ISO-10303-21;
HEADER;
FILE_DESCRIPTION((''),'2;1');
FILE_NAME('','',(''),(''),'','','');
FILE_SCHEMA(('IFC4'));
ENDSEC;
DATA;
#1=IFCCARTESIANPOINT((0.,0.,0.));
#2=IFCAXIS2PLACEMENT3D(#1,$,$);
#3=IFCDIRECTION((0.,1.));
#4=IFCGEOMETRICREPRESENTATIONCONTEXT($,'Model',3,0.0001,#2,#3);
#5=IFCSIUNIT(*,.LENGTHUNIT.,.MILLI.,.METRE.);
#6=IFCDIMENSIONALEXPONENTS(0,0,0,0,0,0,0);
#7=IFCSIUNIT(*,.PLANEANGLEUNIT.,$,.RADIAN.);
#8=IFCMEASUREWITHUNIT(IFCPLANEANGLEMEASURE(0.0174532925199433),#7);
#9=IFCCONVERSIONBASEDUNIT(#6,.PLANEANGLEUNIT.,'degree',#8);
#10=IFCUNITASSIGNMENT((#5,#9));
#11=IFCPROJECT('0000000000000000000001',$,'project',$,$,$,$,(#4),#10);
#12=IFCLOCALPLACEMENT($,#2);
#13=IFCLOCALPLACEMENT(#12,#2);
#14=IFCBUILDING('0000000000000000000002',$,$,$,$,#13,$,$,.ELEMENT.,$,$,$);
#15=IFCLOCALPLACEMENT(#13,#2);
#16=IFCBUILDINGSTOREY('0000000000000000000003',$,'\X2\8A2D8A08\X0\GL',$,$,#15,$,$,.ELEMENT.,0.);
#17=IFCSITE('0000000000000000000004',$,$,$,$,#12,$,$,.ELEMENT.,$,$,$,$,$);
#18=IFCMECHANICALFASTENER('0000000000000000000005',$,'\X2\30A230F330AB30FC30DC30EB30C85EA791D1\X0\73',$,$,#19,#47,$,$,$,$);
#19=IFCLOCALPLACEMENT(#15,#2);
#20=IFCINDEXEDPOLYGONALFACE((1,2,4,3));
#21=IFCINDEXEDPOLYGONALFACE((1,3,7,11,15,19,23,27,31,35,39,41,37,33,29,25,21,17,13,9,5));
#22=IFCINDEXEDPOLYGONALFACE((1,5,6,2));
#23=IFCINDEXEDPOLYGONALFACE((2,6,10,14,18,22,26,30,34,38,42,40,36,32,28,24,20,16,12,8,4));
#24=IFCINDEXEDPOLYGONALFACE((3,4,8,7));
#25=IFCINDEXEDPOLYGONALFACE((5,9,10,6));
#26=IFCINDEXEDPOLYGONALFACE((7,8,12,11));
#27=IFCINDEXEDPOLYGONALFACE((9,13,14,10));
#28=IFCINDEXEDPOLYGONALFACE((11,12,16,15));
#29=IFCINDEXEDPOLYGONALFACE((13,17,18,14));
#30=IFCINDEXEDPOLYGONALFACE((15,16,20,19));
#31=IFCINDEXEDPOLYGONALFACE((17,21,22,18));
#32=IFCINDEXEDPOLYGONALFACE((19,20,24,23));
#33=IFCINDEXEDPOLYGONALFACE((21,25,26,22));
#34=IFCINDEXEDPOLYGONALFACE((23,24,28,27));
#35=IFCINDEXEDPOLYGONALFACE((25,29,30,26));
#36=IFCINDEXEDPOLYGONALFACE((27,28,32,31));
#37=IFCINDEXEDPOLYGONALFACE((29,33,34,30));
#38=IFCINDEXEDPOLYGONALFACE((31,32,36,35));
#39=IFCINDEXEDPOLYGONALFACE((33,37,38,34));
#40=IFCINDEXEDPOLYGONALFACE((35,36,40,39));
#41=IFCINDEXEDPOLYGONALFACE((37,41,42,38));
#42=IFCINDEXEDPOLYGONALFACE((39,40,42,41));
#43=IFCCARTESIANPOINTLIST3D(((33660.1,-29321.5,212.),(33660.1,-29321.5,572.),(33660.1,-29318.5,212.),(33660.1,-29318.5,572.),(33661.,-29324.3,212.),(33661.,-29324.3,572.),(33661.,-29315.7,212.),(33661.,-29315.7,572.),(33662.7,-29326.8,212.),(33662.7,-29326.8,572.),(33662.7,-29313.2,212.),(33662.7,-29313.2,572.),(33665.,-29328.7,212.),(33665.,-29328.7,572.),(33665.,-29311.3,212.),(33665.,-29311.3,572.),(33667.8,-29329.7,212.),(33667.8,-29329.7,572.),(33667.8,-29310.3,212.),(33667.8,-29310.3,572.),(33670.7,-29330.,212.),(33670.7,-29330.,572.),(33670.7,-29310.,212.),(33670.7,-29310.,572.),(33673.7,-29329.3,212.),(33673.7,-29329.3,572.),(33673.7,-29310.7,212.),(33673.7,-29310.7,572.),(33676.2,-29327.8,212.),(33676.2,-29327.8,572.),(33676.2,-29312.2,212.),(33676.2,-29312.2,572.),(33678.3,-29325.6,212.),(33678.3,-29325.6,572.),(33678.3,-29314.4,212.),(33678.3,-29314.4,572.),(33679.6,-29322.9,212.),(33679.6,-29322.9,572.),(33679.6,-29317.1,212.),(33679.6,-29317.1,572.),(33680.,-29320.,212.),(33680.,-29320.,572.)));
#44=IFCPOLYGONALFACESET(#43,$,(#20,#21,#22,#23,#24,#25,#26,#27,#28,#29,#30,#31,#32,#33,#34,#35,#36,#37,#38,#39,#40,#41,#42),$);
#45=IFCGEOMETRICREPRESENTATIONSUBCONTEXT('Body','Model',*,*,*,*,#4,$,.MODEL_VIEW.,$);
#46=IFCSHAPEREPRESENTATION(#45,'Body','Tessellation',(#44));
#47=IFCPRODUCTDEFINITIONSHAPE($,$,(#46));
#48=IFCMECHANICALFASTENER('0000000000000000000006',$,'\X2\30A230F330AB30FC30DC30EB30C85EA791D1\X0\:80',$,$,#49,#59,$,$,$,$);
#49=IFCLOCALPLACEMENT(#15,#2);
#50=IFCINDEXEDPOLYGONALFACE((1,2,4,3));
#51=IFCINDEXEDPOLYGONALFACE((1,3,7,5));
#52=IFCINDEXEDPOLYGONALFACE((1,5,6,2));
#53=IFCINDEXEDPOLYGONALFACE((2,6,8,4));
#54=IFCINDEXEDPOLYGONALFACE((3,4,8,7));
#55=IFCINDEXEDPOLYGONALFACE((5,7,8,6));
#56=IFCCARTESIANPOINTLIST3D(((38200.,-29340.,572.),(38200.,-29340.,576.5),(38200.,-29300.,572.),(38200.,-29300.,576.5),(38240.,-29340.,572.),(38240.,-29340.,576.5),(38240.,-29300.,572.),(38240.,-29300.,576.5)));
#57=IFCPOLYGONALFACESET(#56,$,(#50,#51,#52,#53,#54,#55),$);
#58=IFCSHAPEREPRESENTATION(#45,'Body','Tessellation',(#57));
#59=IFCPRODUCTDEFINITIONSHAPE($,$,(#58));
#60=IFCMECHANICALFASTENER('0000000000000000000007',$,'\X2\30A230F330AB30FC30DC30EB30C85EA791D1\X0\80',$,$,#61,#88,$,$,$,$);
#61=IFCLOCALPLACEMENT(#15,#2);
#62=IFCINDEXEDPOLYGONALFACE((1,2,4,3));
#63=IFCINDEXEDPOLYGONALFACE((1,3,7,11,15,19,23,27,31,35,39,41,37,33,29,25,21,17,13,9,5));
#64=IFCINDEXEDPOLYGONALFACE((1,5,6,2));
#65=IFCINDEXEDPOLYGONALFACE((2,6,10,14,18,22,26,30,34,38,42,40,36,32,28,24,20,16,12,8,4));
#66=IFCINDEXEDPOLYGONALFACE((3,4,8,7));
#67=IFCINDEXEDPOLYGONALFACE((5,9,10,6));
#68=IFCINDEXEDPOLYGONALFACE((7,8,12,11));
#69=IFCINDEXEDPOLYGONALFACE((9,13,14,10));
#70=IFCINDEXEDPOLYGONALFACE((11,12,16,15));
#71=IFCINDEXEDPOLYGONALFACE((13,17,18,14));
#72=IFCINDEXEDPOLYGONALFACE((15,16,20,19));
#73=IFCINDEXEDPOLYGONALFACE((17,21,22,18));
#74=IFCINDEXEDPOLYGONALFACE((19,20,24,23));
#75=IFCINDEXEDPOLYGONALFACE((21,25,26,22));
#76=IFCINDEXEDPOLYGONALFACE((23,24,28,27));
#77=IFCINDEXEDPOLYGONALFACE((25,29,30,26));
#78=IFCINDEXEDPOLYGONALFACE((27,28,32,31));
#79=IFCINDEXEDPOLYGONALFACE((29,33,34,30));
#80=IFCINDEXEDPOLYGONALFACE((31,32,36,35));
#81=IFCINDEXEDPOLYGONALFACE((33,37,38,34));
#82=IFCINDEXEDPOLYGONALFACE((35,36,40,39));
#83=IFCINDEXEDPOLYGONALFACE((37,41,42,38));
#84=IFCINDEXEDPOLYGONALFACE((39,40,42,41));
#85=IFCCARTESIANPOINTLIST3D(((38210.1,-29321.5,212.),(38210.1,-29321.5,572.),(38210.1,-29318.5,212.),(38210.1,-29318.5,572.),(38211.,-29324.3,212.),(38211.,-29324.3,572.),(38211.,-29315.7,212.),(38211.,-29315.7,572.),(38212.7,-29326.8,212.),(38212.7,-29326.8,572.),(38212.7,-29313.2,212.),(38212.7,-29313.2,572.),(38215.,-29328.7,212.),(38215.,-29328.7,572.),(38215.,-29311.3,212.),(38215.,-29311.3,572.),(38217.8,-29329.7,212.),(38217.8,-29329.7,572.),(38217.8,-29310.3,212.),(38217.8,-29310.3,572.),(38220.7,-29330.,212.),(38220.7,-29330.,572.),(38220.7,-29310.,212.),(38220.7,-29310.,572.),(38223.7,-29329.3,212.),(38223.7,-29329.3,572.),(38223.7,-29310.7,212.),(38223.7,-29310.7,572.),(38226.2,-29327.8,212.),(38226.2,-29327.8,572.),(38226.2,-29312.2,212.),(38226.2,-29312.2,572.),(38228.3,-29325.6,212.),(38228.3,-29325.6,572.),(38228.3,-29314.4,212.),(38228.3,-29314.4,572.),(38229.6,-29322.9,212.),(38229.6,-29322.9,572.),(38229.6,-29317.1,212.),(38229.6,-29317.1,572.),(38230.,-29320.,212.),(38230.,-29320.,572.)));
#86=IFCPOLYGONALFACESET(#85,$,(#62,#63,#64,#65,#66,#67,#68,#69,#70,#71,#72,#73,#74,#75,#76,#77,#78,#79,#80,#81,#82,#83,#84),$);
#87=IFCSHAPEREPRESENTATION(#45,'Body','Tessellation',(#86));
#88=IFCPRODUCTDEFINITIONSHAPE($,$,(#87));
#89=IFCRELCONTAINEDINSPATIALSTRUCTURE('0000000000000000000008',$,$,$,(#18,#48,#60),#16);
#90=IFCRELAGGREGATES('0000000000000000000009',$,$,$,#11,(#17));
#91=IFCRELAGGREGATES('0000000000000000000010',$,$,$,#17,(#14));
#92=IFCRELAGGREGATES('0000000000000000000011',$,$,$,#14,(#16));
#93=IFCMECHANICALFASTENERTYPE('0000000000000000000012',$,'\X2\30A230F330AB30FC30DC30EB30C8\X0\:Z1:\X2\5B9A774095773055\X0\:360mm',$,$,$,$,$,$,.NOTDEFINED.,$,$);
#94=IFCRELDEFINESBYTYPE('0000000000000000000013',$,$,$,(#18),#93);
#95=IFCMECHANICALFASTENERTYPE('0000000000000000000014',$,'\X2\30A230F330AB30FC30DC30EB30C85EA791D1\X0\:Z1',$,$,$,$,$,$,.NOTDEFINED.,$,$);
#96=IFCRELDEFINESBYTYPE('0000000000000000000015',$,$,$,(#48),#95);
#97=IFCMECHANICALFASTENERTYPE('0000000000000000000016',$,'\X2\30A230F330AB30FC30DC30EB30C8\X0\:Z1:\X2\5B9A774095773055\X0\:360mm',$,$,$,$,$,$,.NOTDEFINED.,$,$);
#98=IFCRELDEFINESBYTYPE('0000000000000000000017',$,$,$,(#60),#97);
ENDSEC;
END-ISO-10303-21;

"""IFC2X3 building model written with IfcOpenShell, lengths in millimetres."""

from ifc_helpers import new_model, entity, si_unit, converted_unit, direction, frame, origin, origin_with_axes, origin_2d, place, context, subcontext, project, spatial, rectangle, circle, extrude, type_object, element, save


model = new_model("IFC2X3")

# Units and contexts
model_context = context("Model", 3, precision=0.0001, world=origin(), true_north=direction((0.0, 1.0)))
body_context = subcontext(model_context, "Body", "Model", "MODEL_VIEW")
ifc_project = project(units=[si_unit("LENGTHUNIT", "METRE", prefix="MILLI"), converted_unit("PLANEANGLEUNIT", "degree", entity("IfcPlaneAngleMeasure", 0.0174532925199433), si_unit("PLANEANGLEUNIT", "RADIAN"), dimensions=[0, 0, 0, 0, 0, 0, 0])], contexts=[model_context])

# Site, building, storey
site_placement = place(None, origin())
site = spatial("IfcSite", under=ifc_project, at=site_placement, CompositionType="ELEMENT")
building_placement = place(site_placement, origin())
building = spatial("IfcBuilding", under=site, at=building_placement, CompositionType="ELEMENT")
storey_placement = place(building_placement, origin())
storey = spatial("IfcBuildingStorey", under=building, at=storey_placement, Name="設計GL", CompositionType="ELEMENT", Elevation=0.0)

# Mechanical fasteners
mechanical_fastener_type_1 = type_object("IfcMechanicalFastenerType", Name="アンカーボルト:Z1:定着長さ:360mm")
mechanical_fastener_1_placement = place(storey_placement, frame((33670.0, -29320.0, 212.0)))
element("IfcMechanicalFastener", 1, at=mechanical_fastener_1_placement, inside=storey, type_object=mechanical_fastener_type_1, Name="アンカーボルト座金73", context=body_context, shape_type="SweptSolid", body=[
    extrude(circle(Radius=10.0, at=origin_2d()), origin_with_axes(), (0.0, 0.0, 1.0), 360.0),
])
mechanical_fastener_type_2 = type_object("IfcMechanicalFastenerType", Name="アンカーボルト座金:Z1")
mechanical_fastener_2_placement = place(storey_placement, frame((38220.0, -29320.0, 572.0)))
element("IfcMechanicalFastener", 2, at=mechanical_fastener_2_placement, inside=storey, type_object=mechanical_fastener_type_2, Name="アンカーボルト座金:80", context=body_context, shape_type="SweptSolid", body=[
    extrude(rectangle(XDim=40.0, YDim=40.0, at=origin_2d()), origin_with_axes(), (0.0, 0.0, 1.0), 4.5),
])
mechanical_fastener_type_3 = type_object("IfcMechanicalFastenerType", Name="アンカーボルト:Z1:定着長さ:360mm")
mechanical_fastener_3_placement = place(storey_placement, frame((38220.0, -29320.0, 212.0)))
element("IfcMechanicalFastener", 3, at=mechanical_fastener_3_placement, inside=storey, type_object=mechanical_fastener_type_3, Name="アンカーボルト座金80", context=body_context, shape_type="SweptSolid", body=[
    extrude(circle(Radius=10.0, at=origin_2d()), origin_with_axes(), (0.0, 0.0, 1.0), 360.0),
])

save(model, "model.ifc")
